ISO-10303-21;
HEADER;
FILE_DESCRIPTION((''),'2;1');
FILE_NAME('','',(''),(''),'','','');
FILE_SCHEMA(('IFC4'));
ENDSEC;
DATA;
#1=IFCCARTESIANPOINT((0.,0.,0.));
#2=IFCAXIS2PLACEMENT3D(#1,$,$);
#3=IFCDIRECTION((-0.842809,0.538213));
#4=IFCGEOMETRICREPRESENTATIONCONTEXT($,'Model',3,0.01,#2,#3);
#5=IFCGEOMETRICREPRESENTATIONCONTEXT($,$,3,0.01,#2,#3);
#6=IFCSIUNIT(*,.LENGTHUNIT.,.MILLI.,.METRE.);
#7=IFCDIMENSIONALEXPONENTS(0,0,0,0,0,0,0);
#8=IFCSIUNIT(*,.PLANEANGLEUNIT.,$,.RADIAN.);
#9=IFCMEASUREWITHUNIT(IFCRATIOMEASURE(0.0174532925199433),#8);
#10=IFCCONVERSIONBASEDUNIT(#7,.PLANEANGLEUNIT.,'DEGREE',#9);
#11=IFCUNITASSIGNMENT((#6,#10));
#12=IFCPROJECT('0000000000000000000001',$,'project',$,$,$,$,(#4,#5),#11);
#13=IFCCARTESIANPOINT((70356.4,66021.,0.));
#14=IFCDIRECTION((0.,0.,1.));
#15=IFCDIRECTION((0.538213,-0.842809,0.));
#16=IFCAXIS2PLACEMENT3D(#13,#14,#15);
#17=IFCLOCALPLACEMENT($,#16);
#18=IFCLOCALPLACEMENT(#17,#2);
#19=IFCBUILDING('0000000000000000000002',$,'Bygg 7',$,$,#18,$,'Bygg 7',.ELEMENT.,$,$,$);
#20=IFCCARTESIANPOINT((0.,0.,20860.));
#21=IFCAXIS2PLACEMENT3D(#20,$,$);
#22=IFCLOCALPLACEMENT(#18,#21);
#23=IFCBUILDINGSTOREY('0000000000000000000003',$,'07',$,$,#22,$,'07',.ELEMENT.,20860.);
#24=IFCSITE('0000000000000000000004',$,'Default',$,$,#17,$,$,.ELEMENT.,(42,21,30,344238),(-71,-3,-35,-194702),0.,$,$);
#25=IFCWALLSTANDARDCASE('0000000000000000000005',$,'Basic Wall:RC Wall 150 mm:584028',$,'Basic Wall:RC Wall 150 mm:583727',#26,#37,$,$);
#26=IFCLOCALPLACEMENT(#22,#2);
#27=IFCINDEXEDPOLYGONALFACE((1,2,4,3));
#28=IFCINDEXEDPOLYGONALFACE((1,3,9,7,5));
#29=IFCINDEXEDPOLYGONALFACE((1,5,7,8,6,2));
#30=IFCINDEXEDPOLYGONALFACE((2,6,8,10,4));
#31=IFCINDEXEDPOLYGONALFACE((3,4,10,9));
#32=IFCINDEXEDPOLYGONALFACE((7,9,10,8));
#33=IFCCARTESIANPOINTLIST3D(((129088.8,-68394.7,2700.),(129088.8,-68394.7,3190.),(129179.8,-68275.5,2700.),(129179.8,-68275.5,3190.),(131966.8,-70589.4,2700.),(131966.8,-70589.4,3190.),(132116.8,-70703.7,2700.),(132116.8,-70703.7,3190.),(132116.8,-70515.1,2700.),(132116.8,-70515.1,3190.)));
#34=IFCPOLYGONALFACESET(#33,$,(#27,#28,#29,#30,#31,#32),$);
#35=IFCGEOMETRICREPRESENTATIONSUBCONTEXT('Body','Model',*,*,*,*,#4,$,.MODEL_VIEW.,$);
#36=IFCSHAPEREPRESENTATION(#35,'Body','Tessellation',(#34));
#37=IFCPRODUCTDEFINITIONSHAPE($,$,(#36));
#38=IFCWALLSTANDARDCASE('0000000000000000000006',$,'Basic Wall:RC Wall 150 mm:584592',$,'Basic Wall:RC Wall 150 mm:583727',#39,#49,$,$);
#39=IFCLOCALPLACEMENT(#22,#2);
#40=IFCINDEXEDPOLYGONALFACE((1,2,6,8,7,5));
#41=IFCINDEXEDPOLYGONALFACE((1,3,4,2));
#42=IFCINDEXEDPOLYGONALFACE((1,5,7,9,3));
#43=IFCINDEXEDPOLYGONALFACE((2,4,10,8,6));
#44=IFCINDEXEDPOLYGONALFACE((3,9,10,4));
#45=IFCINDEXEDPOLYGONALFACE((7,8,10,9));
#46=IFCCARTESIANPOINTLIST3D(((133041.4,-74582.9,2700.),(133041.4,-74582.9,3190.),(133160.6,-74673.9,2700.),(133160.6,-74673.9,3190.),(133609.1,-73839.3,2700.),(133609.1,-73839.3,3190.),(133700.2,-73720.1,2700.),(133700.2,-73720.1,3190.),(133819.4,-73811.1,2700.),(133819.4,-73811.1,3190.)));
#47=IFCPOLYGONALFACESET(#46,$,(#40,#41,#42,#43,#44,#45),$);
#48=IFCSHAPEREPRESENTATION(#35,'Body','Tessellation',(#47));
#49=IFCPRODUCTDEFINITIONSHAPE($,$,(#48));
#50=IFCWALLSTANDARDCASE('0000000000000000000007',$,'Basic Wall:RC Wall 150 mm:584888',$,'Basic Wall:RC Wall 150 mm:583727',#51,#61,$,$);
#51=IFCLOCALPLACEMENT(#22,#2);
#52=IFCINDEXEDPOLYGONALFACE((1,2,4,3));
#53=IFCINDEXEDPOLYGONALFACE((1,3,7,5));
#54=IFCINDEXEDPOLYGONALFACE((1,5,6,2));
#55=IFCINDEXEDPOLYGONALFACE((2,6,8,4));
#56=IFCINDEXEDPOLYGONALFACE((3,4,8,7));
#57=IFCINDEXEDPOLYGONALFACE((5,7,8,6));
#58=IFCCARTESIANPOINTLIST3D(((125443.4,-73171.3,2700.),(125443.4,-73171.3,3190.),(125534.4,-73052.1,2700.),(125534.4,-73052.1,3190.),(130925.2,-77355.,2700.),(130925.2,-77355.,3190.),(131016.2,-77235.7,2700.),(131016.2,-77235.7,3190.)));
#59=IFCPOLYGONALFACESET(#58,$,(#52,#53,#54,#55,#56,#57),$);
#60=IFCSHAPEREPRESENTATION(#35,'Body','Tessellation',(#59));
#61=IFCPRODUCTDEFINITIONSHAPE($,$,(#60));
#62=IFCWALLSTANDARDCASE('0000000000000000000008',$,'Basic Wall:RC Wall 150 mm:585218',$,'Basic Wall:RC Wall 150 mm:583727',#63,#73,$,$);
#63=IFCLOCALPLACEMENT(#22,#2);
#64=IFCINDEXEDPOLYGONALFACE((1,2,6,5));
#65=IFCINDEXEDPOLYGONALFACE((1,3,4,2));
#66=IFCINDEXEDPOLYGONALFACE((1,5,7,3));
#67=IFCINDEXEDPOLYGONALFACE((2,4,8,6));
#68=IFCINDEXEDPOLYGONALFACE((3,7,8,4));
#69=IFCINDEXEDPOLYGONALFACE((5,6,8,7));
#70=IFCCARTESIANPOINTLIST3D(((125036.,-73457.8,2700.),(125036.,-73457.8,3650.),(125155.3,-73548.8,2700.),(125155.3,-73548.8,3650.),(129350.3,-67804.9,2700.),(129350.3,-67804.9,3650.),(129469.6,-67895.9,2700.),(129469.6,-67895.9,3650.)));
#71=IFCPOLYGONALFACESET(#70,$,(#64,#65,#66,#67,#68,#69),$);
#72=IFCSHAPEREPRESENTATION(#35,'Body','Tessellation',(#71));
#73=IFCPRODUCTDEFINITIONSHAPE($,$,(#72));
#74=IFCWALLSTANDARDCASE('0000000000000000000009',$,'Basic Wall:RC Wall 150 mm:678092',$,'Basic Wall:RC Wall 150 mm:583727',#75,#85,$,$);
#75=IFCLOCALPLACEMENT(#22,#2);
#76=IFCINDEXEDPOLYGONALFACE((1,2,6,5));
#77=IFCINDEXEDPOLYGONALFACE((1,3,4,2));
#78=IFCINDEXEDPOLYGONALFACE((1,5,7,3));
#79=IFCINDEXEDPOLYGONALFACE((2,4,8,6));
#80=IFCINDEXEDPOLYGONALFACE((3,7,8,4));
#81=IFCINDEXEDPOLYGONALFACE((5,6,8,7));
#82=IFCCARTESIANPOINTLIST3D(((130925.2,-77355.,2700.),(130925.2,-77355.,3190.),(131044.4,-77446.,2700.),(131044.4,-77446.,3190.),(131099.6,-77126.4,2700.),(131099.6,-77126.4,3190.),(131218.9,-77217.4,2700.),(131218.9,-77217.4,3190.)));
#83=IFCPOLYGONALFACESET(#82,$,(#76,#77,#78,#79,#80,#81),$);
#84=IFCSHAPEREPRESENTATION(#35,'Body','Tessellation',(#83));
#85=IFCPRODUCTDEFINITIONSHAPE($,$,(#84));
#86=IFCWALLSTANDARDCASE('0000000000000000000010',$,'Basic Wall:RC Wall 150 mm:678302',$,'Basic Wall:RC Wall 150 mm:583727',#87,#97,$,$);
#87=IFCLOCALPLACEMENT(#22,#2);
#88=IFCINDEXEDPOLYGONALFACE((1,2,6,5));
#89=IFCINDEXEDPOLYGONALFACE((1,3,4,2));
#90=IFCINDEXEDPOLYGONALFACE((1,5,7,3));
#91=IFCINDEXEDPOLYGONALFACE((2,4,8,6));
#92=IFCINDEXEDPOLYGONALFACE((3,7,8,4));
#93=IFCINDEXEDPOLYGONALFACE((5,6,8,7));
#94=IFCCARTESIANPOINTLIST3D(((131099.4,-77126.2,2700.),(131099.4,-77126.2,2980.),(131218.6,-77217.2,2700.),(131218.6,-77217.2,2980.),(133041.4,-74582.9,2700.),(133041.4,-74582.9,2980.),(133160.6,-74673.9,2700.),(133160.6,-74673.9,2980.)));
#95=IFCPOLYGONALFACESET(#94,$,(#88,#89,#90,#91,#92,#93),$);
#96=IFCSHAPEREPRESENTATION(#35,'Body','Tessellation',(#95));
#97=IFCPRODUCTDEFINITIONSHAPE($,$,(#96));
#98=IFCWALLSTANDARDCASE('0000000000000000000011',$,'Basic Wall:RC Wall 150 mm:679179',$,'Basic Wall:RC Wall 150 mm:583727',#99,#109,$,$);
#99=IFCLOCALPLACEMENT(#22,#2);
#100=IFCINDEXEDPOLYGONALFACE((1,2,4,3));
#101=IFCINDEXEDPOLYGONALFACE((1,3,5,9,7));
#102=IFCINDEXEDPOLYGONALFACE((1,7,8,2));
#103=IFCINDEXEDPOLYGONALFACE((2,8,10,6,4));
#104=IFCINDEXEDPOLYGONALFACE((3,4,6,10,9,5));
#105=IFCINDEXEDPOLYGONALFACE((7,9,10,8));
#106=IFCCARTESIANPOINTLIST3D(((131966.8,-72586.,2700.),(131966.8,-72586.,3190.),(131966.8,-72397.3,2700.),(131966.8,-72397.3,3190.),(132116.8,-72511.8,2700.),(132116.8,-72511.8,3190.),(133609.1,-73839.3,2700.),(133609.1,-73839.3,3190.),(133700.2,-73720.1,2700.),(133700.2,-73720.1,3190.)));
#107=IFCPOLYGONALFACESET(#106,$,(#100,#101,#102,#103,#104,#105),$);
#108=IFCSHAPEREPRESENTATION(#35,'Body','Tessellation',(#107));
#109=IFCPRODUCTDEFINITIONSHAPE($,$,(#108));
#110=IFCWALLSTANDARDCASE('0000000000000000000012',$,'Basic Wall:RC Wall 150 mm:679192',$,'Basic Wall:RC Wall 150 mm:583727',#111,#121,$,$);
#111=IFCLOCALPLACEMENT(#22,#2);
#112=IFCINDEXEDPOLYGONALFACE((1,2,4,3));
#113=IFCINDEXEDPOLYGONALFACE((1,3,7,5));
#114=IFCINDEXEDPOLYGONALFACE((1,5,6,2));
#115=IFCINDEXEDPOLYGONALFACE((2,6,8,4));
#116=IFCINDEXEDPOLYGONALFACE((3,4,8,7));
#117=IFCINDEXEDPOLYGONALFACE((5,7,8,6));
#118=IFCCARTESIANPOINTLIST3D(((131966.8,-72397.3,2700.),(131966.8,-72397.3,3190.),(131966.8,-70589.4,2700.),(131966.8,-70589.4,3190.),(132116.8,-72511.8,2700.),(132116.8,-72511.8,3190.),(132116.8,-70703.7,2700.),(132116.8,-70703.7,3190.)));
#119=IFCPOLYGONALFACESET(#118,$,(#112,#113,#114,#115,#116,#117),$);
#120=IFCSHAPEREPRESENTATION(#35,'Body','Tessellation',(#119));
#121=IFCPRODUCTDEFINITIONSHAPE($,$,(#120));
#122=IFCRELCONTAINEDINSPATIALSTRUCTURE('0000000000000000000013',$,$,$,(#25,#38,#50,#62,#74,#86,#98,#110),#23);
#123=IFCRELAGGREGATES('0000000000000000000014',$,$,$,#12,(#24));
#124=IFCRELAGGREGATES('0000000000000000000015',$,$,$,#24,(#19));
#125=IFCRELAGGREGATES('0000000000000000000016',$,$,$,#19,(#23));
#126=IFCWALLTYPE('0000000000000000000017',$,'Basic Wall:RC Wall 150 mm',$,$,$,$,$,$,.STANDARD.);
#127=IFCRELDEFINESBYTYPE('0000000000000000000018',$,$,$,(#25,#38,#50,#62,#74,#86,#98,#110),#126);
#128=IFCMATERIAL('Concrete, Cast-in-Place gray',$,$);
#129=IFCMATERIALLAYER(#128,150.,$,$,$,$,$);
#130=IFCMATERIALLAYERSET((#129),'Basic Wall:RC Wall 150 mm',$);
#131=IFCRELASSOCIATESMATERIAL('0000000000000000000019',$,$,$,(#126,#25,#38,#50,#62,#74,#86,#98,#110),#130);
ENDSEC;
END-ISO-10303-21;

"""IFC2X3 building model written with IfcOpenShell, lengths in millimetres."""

from ifc_helpers import new_model, entity, si_unit, converted_unit, direction, frame, frame_2d, origin, place, context, subcontext, project, spatial, polyline, rectangle, outline, extrude, material, layer, layer_set, layer_usage, type_object, element, save


model = new_model("IFC2X3")

# Units and contexts
model_context = context("Model", 3, precision=0.01, world=origin(), true_north=direction((-0.842809, 0.538213)))
context_of_model = context(None, 3, precision=0.01, world=origin(), true_north=direction((-0.842809, 0.538213)))
body_context = subcontext(model_context, "Body", "Model", "MODEL_VIEW")
ifc_project = project(units=[si_unit("LENGTHUNIT", "METRE", prefix="MILLI"), converted_unit("PLANEANGLEUNIT", "DEGREE", entity("IfcRatioMeasure", 0.0174532925199433), si_unit("PLANEANGLEUNIT", "RADIAN"), dimensions=[0, 0, 0, 0, 0, 0, 0])], contexts=[model_context, context_of_model])

# Site, building, storey
site_placement = place(None, frame((70356.4, 66021.0, 0.0), z_axis=(0.0, 0.0, 1.0), x_axis=(0.538213, -0.842809, 0.0)))
site = spatial("IfcSite", under=ifc_project, at=site_placement, Name="Default", CompositionType="ELEMENT", RefLatitude=(42, 21, 30, 344238), RefLongitude=(-71, -3, -35, -194702), RefElevation=0.0)
building_placement = place(site_placement, origin())
building = spatial("IfcBuilding", under=site, at=building_placement, Name="Bygg 7", LongName="Bygg 7", CompositionType="ELEMENT")
storey_placement = place(building_placement, frame((0.0, 0.0, 20860.0)))
storey = spatial("IfcBuildingStorey", under=building, at=storey_placement, Name="07", LongName="07", CompositionType="ELEMENT", Elevation=20860.0)

# Walls
ifc_material = material(Name="Concrete, Cast-in-Place gray")
ifc_layer_1 = layer(ifc_material, 150.0)
ifc_layer_set_1 = layer_set([ifc_layer_1], Name="Basic Wall:RC Wall 150 mm")
ifc_layer_usage_1 = layer_usage(ifc_layer_set_1, "AXIS2", "NEGATIVE", 75.0)
wall_type_1 = type_object("IfcWallType", Name="Basic Wall:RC Wall 150 mm", PredefinedType="STANDARD", material=ifc_layer_set_1)
wall_1_placement = place(storey_placement, frame((129134.3, -68335.1, 2700.0), z_axis=(0.0, 0.0, 1.0), x_axis=(0.795185, -0.606367, 0.0)))
element("IfcWallStandardCase", 1, at=wall_1_placement, inside=storey, type_object=wall_type_1, material=ifc_layer_usage_1, Name="Basic Wall:RC Wall 150 mm:584028", ObjectType="Basic Wall:RC Wall 150 mm:583727", context=body_context, shape_type="SweptSolid", body=[
    extrude(outline(polyline([(3807.9, -75.0), (3693.5, 75.0), (0.1, 75.0), (0.0, -75.0), (3619.3, -75.0), (3807.9, -75.0)])), origin(), (0.0, 0.0, 1.0), 490.0),
])
ifc_layer_usage_2 = layer_usage(ifc_layer_set_1, "AXIS2", "NEGATIVE", 75.0)
wall_2_placement = place(storey_placement, frame((133759.8, -73765.6, 2700.0), z_axis=(0.0, 0.0, 1.0), x_axis=(-0.606881, -0.794793, 0.0)))
element("IfcWallStandardCase", 2, at=wall_2_placement, inside=storey, type_object=wall_type_1, material=ifc_layer_usage_2, Name="Basic Wall:RC Wall 150 mm:584592", ObjectType="Basic Wall:RC Wall 150 mm:583727", context=body_context, shape_type="SweptSolid", body=[
    extrude(outline(polyline([(1085.5, -75.0), (1085.5, 75.0), (0.0, 75.0), (0.0, -75.0), (150.0, -75.0), (1085.5, -75.0)])), origin(), (0.0, 0.0, 1.0), 490.0),
])
ifc_layer_usage_3 = layer_usage(ifc_layer_set_1, "AXIS2", "NEGATIVE", 75.0)
wall_3_placement = place(storey_placement, frame((130970.7, -77295.3, 2700.0), z_axis=(0.0, 0.0, 1.0), x_axis=(-0.794938, 0.60669, 0.0)))
element("IfcWallStandardCase", 3, at=wall_3_placement, inside=storey, type_object=wall_type_1, material=ifc_layer_usage_3, Name="Basic Wall:RC Wall 150 mm:584888", ObjectType="Basic Wall:RC Wall 150 mm:583727", context=body_context, shape_type="SweptSolid", body=[
    extrude(rectangle(XDim=6895.8, YDim=150.0, at=frame_2d((3447.9, 0.0), x_axis=(-1.0, 0.0))), origin(), (0.0, 0.0, 1.0), 490.0),
])
ifc_layer_usage_4 = layer_usage(ifc_layer_set_1, "AXIS2", "NEGATIVE", 75.0)
wall_4_placement = place(storey_placement, frame((125095.7, -73503.3, 2700.0), z_axis=(0.0, 0.0, 1.0), x_axis=(0.60669, 0.794938, 0.0)))
element("IfcWallStandardCase", 4, at=wall_4_placement, inside=storey, type_object=wall_type_1, material=ifc_layer_usage_4, Name="Basic Wall:RC Wall 150 mm:585218", ObjectType="Basic Wall:RC Wall 150 mm:583727", context=body_context, shape_type="SweptSolid", body=[
    extrude(rectangle(XDim=7111.2, YDim=150.0, at=frame_2d((3555.6, 0.0), x_axis=(-1.0, 0.0))), origin(), (0.0, 0.0, 1.0), 950.0),
])
ifc_layer_usage_5 = layer_usage(ifc_layer_set_1, "AXIS2", "NEGATIVE", 75.0)
wall_5_placement = place(storey_placement, frame((131159.2, -77171.9, 2700.0), z_axis=(0.0, 0.0, 1.0), x_axis=(-0.60669, -0.794938, 0.0)))
element("IfcWallStandardCase", 5, at=wall_5_placement, inside=storey, type_object=wall_type_1, material=ifc_layer_usage_5, Name="Basic Wall:RC Wall 150 mm:678092", ObjectType="Basic Wall:RC Wall 150 mm:583727", context=body_context, shape_type="SweptSolid", body=[
    extrude(rectangle(XDim=287.6, YDim=150.0, at=frame_2d((143.8, 0.0), x_axis=(-1.0, 0.0))), origin(), (0.0, 0.0, 1.0), 490.0),
])
ifc_layer_usage_6 = layer_usage(ifc_layer_set_1, "AXIS2", "NEGATIVE", 75.0)
wall_6_placement = place(storey_placement, frame((133101.0, -74628.4, 2700.0), z_axis=(0.0, 0.0, 1.0), x_axis=(-0.606881, -0.794793, 0.0)))
element("IfcWallStandardCase", 6, at=wall_6_placement, inside=storey, type_object=wall_type_1, material=ifc_layer_usage_6, Name="Basic Wall:RC Wall 150 mm:678302", ObjectType="Basic Wall:RC Wall 150 mm:583727", context=body_context, shape_type="SweptSolid", body=[
    extrude(rectangle(XDim=3200.0, YDim=150.0, at=frame_2d((1600.0, 0.0), x_axis=(-1.0, 0.0))), origin(), (0.0, 0.0, 1.0), 280.0),
])
ifc_layer_usage_7 = layer_usage(ifc_layer_set_1, "AXIS2", "NEGATIVE", 75.0)
wall_7_placement = place(storey_placement, frame((131921.3, -72456.9, 2700.0), z_axis=(0.0, 0.0, 1.0), x_axis=(0.794938, -0.60669, 0.0)))
element("IfcWallStandardCase", 7, at=wall_7_placement, inside=storey, type_object=wall_type_1, material=ifc_layer_usage_7, Name="Basic Wall:RC Wall 150 mm:679179", ObjectType="Basic Wall:RC Wall 150 mm:583727", context=body_context, shape_type="SweptSolid", body=[
    extrude(outline(polyline([(2180.4, -75.0), (2180.4, 75.0), (188.7, 75.0), (0.0, 75.0), (114.5, -75.0), (2180.4, -75.0)])), origin(), (0.0, 0.0, 1.0), 490.0),
])
ifc_layer_usage_8 = layer_usage(ifc_layer_set_1, "AXIS2", "NEGATIVE", 75.0)
wall_8_placement = place(storey_placement, frame((132041.8, -70589.4, 2700.0), z_axis=(0.0, 0.0, 1.0), x_axis=(0.0, -1.0, 0.0)))
element("IfcWallStandardCase", 8, at=wall_8_placement, inside=storey, type_object=wall_type_1, material=ifc_layer_usage_8, Name="Basic Wall:RC Wall 150 mm:679192", ObjectType="Basic Wall:RC Wall 150 mm:583727", context=body_context, shape_type="SweptSolid", body=[
    extrude(outline(polyline([(1807.9, -75.0), (1922.4, 75.0), (114.4, 75.0), (0.0, -75.0), (1807.9, -75.0)])), origin(), (0.0, 0.0, 1.0), 490.0),
])

save(model, "model.ifc")
